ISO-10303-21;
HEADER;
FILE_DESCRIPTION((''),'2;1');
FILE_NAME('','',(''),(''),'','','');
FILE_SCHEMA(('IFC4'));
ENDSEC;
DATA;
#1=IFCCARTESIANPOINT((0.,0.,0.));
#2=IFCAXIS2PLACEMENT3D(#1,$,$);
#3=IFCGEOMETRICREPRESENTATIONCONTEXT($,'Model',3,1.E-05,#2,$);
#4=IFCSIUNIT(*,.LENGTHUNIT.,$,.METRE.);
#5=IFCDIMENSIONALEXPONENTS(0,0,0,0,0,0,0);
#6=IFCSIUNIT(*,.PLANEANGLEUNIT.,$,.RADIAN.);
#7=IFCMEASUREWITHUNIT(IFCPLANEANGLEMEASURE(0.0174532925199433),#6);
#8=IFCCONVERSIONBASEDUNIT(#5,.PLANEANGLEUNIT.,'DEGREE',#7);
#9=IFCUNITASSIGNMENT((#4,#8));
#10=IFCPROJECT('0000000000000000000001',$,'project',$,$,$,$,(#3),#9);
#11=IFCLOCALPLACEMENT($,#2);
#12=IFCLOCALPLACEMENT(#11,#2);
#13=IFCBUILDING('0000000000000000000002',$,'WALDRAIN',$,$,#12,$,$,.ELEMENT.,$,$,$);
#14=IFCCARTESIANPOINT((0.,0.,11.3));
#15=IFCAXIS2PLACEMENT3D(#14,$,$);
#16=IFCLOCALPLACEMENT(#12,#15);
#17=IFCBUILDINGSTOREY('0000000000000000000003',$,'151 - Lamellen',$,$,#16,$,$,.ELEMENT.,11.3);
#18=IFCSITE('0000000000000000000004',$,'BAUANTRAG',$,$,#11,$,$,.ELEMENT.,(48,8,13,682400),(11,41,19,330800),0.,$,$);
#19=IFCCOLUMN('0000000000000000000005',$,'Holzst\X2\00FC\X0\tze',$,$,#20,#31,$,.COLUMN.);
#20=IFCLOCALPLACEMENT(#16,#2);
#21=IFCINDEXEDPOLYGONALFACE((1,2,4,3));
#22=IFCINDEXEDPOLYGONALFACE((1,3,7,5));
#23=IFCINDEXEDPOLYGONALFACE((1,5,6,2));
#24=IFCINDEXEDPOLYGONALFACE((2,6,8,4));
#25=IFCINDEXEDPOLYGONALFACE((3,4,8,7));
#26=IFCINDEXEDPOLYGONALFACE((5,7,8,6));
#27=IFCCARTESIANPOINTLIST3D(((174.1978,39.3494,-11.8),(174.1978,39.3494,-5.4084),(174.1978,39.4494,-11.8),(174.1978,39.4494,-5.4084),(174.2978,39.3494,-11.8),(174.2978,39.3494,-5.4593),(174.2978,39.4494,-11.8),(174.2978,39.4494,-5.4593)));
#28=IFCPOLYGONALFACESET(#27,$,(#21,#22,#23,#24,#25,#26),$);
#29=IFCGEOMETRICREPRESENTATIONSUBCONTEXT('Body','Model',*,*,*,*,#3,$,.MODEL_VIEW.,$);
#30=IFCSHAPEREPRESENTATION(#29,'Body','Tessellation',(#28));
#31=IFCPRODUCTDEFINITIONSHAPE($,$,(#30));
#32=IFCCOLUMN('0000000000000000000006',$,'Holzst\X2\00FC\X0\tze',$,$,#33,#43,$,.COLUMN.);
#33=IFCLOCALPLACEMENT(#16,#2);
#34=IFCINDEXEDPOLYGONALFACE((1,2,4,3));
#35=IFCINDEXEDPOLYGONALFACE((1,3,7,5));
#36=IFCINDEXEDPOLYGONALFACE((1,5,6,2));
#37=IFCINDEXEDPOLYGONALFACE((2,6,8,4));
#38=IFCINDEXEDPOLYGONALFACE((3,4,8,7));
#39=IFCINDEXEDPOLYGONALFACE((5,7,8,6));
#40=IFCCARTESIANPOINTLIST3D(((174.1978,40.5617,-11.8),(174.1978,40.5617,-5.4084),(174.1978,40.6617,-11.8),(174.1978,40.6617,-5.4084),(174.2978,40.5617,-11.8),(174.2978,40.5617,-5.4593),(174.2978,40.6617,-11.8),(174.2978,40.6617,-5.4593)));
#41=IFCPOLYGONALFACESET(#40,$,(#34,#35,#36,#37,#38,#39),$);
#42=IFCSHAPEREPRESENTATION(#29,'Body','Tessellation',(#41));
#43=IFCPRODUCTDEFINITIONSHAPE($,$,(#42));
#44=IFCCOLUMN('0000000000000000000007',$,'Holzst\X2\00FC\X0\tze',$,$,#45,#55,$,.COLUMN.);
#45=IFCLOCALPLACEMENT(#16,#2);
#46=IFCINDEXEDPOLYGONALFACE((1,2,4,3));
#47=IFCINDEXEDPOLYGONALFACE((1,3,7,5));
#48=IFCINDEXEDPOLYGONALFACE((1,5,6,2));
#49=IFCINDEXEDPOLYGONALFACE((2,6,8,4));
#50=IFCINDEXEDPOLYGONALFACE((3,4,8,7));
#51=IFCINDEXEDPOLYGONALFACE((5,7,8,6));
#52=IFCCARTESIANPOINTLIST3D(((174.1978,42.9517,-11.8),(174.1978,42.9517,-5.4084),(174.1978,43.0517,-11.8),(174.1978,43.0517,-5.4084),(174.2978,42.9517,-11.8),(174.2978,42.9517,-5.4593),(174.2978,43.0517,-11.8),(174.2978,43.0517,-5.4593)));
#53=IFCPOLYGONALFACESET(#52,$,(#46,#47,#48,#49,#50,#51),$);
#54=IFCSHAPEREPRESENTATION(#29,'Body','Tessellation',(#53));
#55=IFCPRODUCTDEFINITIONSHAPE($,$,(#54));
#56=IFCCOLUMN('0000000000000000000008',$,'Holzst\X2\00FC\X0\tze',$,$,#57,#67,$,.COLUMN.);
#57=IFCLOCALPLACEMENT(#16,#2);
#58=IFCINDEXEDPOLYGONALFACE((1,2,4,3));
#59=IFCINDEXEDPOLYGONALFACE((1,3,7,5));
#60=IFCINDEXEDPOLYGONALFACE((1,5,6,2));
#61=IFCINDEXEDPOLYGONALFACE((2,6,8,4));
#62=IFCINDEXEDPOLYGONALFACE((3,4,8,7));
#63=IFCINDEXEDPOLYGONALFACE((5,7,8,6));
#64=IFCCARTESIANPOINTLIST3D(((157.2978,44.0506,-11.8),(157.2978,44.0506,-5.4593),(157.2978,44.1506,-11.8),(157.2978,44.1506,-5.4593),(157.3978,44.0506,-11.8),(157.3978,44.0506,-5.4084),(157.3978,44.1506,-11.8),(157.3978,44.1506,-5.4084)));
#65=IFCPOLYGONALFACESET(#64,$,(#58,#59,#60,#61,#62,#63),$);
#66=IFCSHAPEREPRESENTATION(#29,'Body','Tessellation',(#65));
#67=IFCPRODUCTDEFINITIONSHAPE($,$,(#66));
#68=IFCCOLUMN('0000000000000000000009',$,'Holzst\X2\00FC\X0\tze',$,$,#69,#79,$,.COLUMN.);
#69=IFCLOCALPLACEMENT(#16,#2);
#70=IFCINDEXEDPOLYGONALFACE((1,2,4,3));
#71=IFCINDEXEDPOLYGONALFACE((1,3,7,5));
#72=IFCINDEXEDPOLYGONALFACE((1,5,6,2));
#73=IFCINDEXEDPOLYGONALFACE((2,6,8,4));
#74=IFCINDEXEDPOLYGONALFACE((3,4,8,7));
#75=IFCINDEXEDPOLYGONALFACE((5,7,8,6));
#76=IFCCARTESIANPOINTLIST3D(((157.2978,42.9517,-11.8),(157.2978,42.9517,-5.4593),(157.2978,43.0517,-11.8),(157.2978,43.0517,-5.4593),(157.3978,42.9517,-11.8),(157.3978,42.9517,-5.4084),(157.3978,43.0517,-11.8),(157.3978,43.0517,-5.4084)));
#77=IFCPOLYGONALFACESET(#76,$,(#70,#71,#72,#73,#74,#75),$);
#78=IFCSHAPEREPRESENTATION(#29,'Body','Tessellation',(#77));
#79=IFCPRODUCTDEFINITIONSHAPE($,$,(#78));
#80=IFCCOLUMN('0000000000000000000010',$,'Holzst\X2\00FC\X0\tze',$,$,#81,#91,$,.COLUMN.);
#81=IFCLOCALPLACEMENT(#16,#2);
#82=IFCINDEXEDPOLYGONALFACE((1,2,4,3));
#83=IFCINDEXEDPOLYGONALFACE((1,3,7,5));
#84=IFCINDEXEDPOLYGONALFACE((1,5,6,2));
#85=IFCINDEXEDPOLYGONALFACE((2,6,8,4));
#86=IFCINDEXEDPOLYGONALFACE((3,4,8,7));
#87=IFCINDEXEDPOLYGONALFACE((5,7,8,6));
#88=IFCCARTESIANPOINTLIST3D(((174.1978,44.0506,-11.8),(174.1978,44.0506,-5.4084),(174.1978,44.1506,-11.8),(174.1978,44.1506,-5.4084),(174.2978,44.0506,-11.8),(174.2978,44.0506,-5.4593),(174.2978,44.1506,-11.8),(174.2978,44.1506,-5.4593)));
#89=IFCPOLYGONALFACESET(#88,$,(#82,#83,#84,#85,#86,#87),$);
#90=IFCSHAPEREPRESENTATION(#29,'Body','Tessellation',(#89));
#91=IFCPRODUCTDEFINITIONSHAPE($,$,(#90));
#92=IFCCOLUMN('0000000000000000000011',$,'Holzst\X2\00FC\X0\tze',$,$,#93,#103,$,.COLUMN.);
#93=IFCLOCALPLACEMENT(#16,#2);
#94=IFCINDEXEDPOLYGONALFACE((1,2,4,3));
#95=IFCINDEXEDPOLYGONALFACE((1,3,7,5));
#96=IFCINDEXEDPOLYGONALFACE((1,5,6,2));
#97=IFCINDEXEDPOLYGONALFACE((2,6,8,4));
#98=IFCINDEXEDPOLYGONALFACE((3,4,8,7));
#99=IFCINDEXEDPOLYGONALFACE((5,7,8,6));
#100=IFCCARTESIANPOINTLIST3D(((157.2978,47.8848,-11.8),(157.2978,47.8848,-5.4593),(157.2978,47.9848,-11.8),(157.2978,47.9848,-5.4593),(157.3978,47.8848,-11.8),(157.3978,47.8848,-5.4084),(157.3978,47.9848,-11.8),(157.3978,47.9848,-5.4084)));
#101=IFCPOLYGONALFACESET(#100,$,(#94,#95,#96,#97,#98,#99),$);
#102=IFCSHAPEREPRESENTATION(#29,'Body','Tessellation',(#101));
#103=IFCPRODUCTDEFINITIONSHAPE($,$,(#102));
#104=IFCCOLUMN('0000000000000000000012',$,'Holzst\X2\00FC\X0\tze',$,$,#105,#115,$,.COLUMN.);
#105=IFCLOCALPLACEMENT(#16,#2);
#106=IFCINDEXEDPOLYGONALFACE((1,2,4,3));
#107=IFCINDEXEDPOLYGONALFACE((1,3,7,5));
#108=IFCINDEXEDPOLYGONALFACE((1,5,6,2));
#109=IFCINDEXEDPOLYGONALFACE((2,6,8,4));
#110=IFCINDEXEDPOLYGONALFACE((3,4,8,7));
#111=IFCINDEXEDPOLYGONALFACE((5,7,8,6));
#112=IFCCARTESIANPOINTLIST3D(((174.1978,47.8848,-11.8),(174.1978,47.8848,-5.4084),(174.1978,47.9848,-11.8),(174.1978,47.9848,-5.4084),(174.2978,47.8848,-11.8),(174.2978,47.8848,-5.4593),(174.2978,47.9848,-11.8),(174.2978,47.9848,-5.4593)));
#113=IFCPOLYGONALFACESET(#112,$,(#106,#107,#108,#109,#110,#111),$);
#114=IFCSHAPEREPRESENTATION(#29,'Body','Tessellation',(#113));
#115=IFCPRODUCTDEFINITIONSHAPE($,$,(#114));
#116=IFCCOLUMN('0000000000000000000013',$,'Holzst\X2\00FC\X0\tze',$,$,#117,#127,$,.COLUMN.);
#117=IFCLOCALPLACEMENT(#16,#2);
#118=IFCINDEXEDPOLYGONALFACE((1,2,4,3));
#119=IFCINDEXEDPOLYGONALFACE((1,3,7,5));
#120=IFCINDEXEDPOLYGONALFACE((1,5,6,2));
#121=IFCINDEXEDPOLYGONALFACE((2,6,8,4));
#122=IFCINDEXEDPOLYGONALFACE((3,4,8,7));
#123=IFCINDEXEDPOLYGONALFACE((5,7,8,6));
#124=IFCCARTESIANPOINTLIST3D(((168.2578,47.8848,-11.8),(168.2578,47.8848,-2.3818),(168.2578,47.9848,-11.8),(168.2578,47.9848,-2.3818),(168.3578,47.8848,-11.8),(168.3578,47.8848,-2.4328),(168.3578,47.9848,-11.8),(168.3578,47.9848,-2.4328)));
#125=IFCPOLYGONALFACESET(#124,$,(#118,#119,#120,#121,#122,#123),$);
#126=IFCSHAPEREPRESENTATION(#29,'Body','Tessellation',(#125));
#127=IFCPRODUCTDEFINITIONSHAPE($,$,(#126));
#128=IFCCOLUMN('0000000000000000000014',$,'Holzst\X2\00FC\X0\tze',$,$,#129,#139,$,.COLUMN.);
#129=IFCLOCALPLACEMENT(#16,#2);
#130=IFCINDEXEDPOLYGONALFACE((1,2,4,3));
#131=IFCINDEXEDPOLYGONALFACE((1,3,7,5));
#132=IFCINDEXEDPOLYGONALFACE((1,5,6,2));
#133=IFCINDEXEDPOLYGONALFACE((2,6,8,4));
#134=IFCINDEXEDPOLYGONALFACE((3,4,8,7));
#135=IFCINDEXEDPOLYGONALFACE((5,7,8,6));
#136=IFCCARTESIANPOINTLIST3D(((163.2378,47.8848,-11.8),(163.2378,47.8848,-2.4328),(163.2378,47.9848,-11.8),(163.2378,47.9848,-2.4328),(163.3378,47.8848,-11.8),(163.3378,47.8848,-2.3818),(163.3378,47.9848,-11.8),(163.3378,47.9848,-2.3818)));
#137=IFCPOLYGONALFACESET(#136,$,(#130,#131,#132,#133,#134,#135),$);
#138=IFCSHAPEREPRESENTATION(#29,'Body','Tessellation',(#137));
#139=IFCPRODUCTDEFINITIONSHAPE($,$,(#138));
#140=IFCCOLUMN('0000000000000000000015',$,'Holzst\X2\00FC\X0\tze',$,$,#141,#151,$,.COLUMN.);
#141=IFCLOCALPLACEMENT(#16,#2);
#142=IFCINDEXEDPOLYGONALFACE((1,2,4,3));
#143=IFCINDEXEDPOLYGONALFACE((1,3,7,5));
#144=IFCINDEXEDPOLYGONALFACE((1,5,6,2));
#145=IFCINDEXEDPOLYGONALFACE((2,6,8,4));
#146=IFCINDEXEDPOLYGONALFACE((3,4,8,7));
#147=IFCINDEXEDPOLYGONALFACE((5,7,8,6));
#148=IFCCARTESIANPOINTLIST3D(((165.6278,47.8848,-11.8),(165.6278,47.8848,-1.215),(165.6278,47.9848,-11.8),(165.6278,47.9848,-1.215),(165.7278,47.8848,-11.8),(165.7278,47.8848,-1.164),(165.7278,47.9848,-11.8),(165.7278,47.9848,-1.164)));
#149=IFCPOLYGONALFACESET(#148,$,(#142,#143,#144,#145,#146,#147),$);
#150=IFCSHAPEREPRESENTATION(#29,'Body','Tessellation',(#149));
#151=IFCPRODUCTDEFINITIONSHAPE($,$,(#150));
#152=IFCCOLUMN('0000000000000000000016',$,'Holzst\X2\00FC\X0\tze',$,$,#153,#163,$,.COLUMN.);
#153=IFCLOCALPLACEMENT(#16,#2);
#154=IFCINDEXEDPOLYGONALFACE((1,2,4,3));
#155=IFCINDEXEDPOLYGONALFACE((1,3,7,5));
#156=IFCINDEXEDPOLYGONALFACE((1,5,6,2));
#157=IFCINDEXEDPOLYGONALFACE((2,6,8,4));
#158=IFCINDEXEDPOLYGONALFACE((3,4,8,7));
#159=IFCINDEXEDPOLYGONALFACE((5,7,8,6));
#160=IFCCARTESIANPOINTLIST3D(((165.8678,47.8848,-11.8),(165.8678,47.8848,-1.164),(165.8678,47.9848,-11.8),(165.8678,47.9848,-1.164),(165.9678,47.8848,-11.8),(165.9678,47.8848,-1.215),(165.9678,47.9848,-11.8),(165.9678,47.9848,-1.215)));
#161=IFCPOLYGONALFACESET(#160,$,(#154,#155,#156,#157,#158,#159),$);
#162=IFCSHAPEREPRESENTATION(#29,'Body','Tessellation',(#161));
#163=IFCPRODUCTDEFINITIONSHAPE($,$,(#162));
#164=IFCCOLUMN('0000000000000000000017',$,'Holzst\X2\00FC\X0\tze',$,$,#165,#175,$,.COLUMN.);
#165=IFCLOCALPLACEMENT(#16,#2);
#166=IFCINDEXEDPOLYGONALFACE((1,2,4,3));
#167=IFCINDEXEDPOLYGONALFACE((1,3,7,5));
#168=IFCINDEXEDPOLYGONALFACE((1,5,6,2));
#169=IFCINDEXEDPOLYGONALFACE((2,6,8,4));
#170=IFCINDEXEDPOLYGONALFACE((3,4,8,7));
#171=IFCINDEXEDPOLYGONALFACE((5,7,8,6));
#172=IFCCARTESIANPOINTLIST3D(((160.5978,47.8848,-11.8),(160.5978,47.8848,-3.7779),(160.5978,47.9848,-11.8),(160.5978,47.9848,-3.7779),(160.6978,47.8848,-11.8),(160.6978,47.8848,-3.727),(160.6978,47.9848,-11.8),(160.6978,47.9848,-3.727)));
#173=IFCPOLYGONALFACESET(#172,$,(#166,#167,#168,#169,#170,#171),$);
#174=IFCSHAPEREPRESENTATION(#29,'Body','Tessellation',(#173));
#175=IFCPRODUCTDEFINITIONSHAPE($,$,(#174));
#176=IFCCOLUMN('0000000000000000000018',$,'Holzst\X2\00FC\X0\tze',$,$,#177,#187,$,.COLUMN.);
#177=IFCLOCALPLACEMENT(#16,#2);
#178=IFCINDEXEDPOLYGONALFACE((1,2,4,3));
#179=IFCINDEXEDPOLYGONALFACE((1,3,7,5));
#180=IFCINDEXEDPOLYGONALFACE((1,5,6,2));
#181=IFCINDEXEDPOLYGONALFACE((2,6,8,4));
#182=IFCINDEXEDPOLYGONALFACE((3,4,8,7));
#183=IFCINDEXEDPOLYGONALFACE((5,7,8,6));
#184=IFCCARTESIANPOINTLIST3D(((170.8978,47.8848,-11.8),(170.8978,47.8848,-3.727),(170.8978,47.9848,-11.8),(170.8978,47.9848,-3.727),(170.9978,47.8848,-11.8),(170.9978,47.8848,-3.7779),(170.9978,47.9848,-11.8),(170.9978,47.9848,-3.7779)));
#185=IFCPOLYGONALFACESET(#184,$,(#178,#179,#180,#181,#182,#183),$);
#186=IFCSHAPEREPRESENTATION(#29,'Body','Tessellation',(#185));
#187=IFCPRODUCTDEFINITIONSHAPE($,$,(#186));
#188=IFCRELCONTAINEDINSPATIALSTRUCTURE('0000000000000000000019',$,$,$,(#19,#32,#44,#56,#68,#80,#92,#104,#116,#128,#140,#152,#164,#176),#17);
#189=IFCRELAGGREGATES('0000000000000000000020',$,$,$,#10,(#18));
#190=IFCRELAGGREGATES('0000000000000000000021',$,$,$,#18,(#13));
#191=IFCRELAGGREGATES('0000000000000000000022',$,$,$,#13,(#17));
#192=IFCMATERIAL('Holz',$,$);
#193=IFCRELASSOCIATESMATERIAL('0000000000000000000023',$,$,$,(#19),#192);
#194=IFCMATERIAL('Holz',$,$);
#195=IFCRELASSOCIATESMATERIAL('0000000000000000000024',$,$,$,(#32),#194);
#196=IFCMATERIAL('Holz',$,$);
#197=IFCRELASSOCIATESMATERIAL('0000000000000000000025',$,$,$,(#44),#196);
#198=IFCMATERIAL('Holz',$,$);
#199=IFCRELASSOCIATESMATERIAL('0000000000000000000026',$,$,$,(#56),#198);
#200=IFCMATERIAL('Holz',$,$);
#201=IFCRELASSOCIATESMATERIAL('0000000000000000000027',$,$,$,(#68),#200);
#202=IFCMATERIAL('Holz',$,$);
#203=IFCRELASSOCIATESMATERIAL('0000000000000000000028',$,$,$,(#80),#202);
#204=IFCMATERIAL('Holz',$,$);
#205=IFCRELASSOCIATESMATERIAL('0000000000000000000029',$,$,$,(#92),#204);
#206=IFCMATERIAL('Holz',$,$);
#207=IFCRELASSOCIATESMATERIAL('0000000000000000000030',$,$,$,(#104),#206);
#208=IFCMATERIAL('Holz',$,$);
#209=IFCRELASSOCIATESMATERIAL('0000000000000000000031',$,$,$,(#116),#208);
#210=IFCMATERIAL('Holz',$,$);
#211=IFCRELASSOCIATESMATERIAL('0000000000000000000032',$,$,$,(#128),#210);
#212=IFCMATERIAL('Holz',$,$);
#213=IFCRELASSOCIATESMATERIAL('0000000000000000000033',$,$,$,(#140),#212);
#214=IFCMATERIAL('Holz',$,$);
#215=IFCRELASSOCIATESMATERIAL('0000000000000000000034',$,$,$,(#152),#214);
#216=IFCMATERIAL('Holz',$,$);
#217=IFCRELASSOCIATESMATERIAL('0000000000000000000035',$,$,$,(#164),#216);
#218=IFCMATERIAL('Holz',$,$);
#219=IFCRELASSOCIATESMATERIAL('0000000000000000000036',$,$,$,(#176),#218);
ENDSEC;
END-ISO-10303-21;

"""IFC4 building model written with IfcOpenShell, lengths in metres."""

from ifc_helpers import new_model, entity, si_unit, converted_unit, frame, frame_2d, origin, origin_with_axes, place, context, subcontext, project, spatial, rectangle, extrude, clip, halfspace, material, element, save


model = new_model("IFC4")

# Units and contexts
model_context = context("Model", 3, precision=1e-05, world=origin())
body_context = subcontext(model_context, "Body", "Model", "MODEL_VIEW")
ifc_project = project(units=[si_unit("LENGTHUNIT", "METRE"), converted_unit("PLANEANGLEUNIT", "DEGREE", entity("IfcPlaneAngleMeasure", 0.0174532925199433), si_unit("PLANEANGLEUNIT", "RADIAN"), dimensions=[0, 0, 0, 0, 0, 0, 0])], contexts=[model_context])

# Site, building, storey
site_placement = place(None, origin())
site = spatial("IfcSite", under=ifc_project, at=site_placement, Name="BAUANTRAG", CompositionType="ELEMENT", RefLatitude=(48, 8, 13, 682400), RefLongitude=(11, 41, 19, 330800), RefElevation=0.0)
building_placement = place(site_placement, origin())
building = spatial("IfcBuilding", under=site, at=building_placement, Name="WALDRAIN", CompositionType="ELEMENT")
storey_placement = place(building_placement, frame((0.0, 0.0, 11.3)))
storey = spatial("IfcBuildingStorey", under=building, at=storey_placement, Name="151 - Lamellen", CompositionType="ELEMENT", Elevation=11.3)

# Columns
ifc_material_1 = material(Name="Holz")
column_1_placement = place(storey_placement, frame((174.2978, 39.3494, -11.8)))
element("IfcColumn", 1, at=column_1_placement, inside=storey, material=ifc_material_1, Name="Holzstütze", PredefinedType="COLUMN", context=body_context, shape_type="Clipping", body=[
    clip(extrude(rectangle(XDim=0.1, YDim=0.1, at=frame_2d((-0.05, 0.05), x_axis=(0.0, 1.0))), origin_with_axes(), (0.0, 0.0, 1.0), 6.3916), halfspace(frame((-0.05, 0.05, 6.3661), z_axis=(-0.45399, 0.0, -0.891007), x_axis=(0.891007, 0.0, -0.45399)), True)),
])
ifc_material_2 = material(Name="Holz")
column_2_placement = place(storey_placement, frame((174.2978, 40.5617, -11.8)))
element("IfcColumn", 2, at=column_2_placement, inside=storey, material=ifc_material_2, Name="Holzstütze", PredefinedType="COLUMN", context=body_context, shape_type="Clipping", body=[
    clip(extrude(rectangle(XDim=0.1, YDim=0.1, at=frame_2d((-0.05, 0.05), x_axis=(0.0, 1.0))), origin_with_axes(), (0.0, 0.0, 1.0), 6.3916), halfspace(frame((-0.05, 0.05, 6.3661), z_axis=(-0.45399, 0.0, -0.891007), x_axis=(0.891007, 0.0, -0.45399)), True)),
])
ifc_material_3 = material(Name="Holz")
column_3_placement = place(storey_placement, frame((174.2978, 42.9517, -11.8)))
element("IfcColumn", 3, at=column_3_placement, inside=storey, material=ifc_material_3, Name="Holzstütze", PredefinedType="COLUMN", context=body_context, shape_type="Clipping", body=[
    clip(extrude(rectangle(XDim=0.1, YDim=0.1, at=frame_2d((-0.05, 0.05), x_axis=(0.0, 1.0))), origin_with_axes(), (0.0, 0.0, 1.0), 6.3916), halfspace(frame((-0.05, 0.05, 6.3661), z_axis=(-0.45399, 0.0, -0.891007), x_axis=(0.891007, 0.0, -0.45399)), True)),
])
ifc_material_4 = material(Name="Holz")
column_4_placement = place(storey_placement, frame((157.3978, 44.0506, -11.8)))
element("IfcColumn", 4, at=column_4_placement, inside=storey, material=ifc_material_4, Name="Holzstütze", PredefinedType="COLUMN", context=body_context, shape_type="Clipping", body=[
    clip(extrude(rectangle(XDim=0.1, YDim=0.1, at=frame_2d((-0.05, 0.05), x_axis=(0.0, 1.0))), origin_with_axes(), (0.0, 0.0, 1.0), 6.3916), halfspace(frame((-0.05, 0.05, 6.3661), z_axis=(0.45399, 0.0, -0.891007), x_axis=(-0.891007, 0.0, -0.45399)), True)),
])
ifc_material_5 = material(Name="Holz")
column_5_placement = place(storey_placement, frame((157.3978, 42.9517, -11.8)))
element("IfcColumn", 5, at=column_5_placement, inside=storey, material=ifc_material_5, Name="Holzstütze", PredefinedType="COLUMN", context=body_context, shape_type="Clipping", body=[
    clip(extrude(rectangle(XDim=0.1, YDim=0.1, at=frame_2d((-0.05, 0.05), x_axis=(0.0, 1.0))), origin_with_axes(), (0.0, 0.0, 1.0), 6.3916), halfspace(frame((-0.05, 0.05, 6.3661), z_axis=(0.45399, 0.0, -0.891007), x_axis=(-0.891007, 0.0, -0.45399)), True)),
])
ifc_material_6 = material(Name="Holz")
column_6_placement = place(storey_placement, frame((174.2978, 44.0506, -11.8)))
element("IfcColumn", 6, at=column_6_placement, inside=storey, material=ifc_material_6, Name="Holzstütze", PredefinedType="COLUMN", context=body_context, shape_type="Clipping", body=[
    clip(extrude(rectangle(XDim=0.1, YDim=0.1, at=frame_2d((-0.05, 0.05), x_axis=(0.0, 1.0))), origin_with_axes(), (0.0, 0.0, 1.0), 6.3916), halfspace(frame((-0.05, 0.05, 6.3661), z_axis=(-0.45399, 0.0, -0.891007), x_axis=(0.891007, 0.0, -0.45399)), True)),
])
ifc_material_7 = material(Name="Holz")
column_7_placement = place(storey_placement, frame((157.3978, 47.8848, -11.8)))
element("IfcColumn", 7, at=column_7_placement, inside=storey, material=ifc_material_7, Name="Holzstütze", PredefinedType="COLUMN", context=body_context, shape_type="Clipping", body=[
    clip(extrude(rectangle(XDim=0.1, YDim=0.1, at=frame_2d((-0.05, 0.05), x_axis=(0.0, 1.0))), origin_with_axes(), (0.0, 0.0, 1.0), 6.3916), halfspace(frame((-0.05, 0.05, 6.3661), z_axis=(0.45399, 0.0, -0.891007), x_axis=(0.0, 1.0, 0.0)), True)),
])
ifc_material_8 = material(Name="Holz")
column_8_placement = place(storey_placement, frame((174.2978, 47.8848, -11.8)))
element("IfcColumn", 8, at=column_8_placement, inside=storey, material=ifc_material_8, Name="Holzstütze", PredefinedType="COLUMN", context=body_context, shape_type="Clipping", body=[
    clip(extrude(rectangle(XDim=0.1, YDim=0.1, at=frame_2d((-0.05, 0.05), x_axis=(0.0, 1.0))), origin_with_axes(), (0.0, 0.0, 1.0), 6.3916), halfspace(frame((-0.05, 0.05, 6.3661), z_axis=(-0.45399, 0.0, -0.891007), x_axis=(0.891007, 0.0, -0.45399)), True)),
])
ifc_material_9 = material(Name="Holz")
column_9_placement = place(storey_placement, frame((168.3578, 47.8848, -11.8)))
element("IfcColumn", 9, at=column_9_placement, inside=storey, material=ifc_material_9, Name="Holzstütze", PredefinedType="COLUMN", context=body_context, shape_type="Clipping", body=[
    clip(extrude(rectangle(XDim=0.1, YDim=0.1, at=frame_2d((-0.05, 0.05), x_axis=(0.0, 1.0))), origin_with_axes(), (0.0, 0.0, 1.0), 9.4182), halfspace(frame((-0.05, 0.05, 9.3927), z_axis=(-0.45399, 0.0, -0.891007), x_axis=(0.0, 1.0, 0.0)), True)),
])
ifc_material_10 = material(Name="Holz")
column_10_placement = place(storey_placement, frame((163.3378, 47.8848, -11.8)))
element("IfcColumn", 10, at=column_10_placement, inside=storey, material=ifc_material_10, Name="Holzstütze", PredefinedType="COLUMN", context=body_context, shape_type="Clipping", body=[
    clip(extrude(rectangle(XDim=0.1, YDim=0.1, at=frame_2d((-0.05, 0.05), x_axis=(0.0, 1.0))), origin_with_axes(), (0.0, 0.0, 1.0), 9.4182), halfspace(frame((-0.05, 0.05, 9.3927), z_axis=(0.45399, 0.0, -0.891007), x_axis=(0.0, 1.0, 0.0)), True)),
])
ifc_material_11 = material(Name="Holz")
column_11_placement = place(storey_placement, frame((165.7278, 47.8848, -11.8)))
element("IfcColumn", 11, at=column_11_placement, inside=storey, material=ifc_material_11, Name="Holzstütze", PredefinedType="COLUMN", context=body_context, shape_type="Clipping", body=[
    clip(extrude(rectangle(XDim=0.1, YDim=0.1, at=frame_2d((-0.05, 0.05), x_axis=(0.0, 1.0))), origin_with_axes(), (0.0, 0.0, 1.0), 10.636), halfspace(frame((-0.05, 0.05, 10.6105), z_axis=(0.45399, 0.0, -0.891007), x_axis=(0.0, 1.0, 0.0)), True)),
])
ifc_material_12 = material(Name="Holz")
column_12_placement = place(storey_placement, frame((165.9678, 47.8848, -11.8)))
element("IfcColumn", 12, at=column_12_placement, inside=storey, material=ifc_material_12, Name="Holzstütze", PredefinedType="COLUMN", context=body_context, shape_type="Clipping", body=[
    clip(extrude(rectangle(XDim=0.1, YDim=0.1, at=frame_2d((-0.05, 0.05), x_axis=(0.0, 1.0))), origin_with_axes(), (0.0, 0.0, 1.0), 10.636), halfspace(frame((-0.05, 0.05, 10.6105), z_axis=(-0.45399, 0.0, -0.891007), x_axis=(0.0, 1.0, 0.0)), True)),
])
ifc_material_13 = material(Name="Holz")
column_13_placement = place(storey_placement, frame((160.6978, 47.8848, -11.8)))
element("IfcColumn", 13, at=column_13_placement, inside=storey, material=ifc_material_13, Name="Holzstütze", PredefinedType="COLUMN", context=body_context, shape_type="Clipping", body=[
    clip(extrude(rectangle(XDim=0.1, YDim=0.1, at=frame_2d((-0.05, 0.05), x_axis=(0.0, 1.0))), origin_with_axes(), (0.0, 0.0, 1.0), 8.073), halfspace(frame((-0.05, 0.05, 8.0476), z_axis=(0.45399, 0.0, -0.891007), x_axis=(0.0, 1.0, 0.0)), True)),
])
ifc_material_14 = material(Name="Holz")
column_14_placement = place(storey_placement, frame((170.9978, 47.8848, -11.8)))
element("IfcColumn", 14, at=column_14_placement, inside=storey, material=ifc_material_14, Name="Holzstütze", PredefinedType="COLUMN", context=body_context, shape_type="Clipping", body=[
    clip(extrude(rectangle(XDim=0.1, YDim=0.1, at=frame_2d((-0.05, 0.05), x_axis=(0.0, 1.0))), origin_with_axes(), (0.0, 0.0, 1.0), 8.073), halfspace(frame((-0.05, 0.05, 8.0476), z_axis=(-0.45399, 0.0, -0.891007), x_axis=(0.0, 1.0, 0.0)), True)),
])

save(model, "model.ifc")
